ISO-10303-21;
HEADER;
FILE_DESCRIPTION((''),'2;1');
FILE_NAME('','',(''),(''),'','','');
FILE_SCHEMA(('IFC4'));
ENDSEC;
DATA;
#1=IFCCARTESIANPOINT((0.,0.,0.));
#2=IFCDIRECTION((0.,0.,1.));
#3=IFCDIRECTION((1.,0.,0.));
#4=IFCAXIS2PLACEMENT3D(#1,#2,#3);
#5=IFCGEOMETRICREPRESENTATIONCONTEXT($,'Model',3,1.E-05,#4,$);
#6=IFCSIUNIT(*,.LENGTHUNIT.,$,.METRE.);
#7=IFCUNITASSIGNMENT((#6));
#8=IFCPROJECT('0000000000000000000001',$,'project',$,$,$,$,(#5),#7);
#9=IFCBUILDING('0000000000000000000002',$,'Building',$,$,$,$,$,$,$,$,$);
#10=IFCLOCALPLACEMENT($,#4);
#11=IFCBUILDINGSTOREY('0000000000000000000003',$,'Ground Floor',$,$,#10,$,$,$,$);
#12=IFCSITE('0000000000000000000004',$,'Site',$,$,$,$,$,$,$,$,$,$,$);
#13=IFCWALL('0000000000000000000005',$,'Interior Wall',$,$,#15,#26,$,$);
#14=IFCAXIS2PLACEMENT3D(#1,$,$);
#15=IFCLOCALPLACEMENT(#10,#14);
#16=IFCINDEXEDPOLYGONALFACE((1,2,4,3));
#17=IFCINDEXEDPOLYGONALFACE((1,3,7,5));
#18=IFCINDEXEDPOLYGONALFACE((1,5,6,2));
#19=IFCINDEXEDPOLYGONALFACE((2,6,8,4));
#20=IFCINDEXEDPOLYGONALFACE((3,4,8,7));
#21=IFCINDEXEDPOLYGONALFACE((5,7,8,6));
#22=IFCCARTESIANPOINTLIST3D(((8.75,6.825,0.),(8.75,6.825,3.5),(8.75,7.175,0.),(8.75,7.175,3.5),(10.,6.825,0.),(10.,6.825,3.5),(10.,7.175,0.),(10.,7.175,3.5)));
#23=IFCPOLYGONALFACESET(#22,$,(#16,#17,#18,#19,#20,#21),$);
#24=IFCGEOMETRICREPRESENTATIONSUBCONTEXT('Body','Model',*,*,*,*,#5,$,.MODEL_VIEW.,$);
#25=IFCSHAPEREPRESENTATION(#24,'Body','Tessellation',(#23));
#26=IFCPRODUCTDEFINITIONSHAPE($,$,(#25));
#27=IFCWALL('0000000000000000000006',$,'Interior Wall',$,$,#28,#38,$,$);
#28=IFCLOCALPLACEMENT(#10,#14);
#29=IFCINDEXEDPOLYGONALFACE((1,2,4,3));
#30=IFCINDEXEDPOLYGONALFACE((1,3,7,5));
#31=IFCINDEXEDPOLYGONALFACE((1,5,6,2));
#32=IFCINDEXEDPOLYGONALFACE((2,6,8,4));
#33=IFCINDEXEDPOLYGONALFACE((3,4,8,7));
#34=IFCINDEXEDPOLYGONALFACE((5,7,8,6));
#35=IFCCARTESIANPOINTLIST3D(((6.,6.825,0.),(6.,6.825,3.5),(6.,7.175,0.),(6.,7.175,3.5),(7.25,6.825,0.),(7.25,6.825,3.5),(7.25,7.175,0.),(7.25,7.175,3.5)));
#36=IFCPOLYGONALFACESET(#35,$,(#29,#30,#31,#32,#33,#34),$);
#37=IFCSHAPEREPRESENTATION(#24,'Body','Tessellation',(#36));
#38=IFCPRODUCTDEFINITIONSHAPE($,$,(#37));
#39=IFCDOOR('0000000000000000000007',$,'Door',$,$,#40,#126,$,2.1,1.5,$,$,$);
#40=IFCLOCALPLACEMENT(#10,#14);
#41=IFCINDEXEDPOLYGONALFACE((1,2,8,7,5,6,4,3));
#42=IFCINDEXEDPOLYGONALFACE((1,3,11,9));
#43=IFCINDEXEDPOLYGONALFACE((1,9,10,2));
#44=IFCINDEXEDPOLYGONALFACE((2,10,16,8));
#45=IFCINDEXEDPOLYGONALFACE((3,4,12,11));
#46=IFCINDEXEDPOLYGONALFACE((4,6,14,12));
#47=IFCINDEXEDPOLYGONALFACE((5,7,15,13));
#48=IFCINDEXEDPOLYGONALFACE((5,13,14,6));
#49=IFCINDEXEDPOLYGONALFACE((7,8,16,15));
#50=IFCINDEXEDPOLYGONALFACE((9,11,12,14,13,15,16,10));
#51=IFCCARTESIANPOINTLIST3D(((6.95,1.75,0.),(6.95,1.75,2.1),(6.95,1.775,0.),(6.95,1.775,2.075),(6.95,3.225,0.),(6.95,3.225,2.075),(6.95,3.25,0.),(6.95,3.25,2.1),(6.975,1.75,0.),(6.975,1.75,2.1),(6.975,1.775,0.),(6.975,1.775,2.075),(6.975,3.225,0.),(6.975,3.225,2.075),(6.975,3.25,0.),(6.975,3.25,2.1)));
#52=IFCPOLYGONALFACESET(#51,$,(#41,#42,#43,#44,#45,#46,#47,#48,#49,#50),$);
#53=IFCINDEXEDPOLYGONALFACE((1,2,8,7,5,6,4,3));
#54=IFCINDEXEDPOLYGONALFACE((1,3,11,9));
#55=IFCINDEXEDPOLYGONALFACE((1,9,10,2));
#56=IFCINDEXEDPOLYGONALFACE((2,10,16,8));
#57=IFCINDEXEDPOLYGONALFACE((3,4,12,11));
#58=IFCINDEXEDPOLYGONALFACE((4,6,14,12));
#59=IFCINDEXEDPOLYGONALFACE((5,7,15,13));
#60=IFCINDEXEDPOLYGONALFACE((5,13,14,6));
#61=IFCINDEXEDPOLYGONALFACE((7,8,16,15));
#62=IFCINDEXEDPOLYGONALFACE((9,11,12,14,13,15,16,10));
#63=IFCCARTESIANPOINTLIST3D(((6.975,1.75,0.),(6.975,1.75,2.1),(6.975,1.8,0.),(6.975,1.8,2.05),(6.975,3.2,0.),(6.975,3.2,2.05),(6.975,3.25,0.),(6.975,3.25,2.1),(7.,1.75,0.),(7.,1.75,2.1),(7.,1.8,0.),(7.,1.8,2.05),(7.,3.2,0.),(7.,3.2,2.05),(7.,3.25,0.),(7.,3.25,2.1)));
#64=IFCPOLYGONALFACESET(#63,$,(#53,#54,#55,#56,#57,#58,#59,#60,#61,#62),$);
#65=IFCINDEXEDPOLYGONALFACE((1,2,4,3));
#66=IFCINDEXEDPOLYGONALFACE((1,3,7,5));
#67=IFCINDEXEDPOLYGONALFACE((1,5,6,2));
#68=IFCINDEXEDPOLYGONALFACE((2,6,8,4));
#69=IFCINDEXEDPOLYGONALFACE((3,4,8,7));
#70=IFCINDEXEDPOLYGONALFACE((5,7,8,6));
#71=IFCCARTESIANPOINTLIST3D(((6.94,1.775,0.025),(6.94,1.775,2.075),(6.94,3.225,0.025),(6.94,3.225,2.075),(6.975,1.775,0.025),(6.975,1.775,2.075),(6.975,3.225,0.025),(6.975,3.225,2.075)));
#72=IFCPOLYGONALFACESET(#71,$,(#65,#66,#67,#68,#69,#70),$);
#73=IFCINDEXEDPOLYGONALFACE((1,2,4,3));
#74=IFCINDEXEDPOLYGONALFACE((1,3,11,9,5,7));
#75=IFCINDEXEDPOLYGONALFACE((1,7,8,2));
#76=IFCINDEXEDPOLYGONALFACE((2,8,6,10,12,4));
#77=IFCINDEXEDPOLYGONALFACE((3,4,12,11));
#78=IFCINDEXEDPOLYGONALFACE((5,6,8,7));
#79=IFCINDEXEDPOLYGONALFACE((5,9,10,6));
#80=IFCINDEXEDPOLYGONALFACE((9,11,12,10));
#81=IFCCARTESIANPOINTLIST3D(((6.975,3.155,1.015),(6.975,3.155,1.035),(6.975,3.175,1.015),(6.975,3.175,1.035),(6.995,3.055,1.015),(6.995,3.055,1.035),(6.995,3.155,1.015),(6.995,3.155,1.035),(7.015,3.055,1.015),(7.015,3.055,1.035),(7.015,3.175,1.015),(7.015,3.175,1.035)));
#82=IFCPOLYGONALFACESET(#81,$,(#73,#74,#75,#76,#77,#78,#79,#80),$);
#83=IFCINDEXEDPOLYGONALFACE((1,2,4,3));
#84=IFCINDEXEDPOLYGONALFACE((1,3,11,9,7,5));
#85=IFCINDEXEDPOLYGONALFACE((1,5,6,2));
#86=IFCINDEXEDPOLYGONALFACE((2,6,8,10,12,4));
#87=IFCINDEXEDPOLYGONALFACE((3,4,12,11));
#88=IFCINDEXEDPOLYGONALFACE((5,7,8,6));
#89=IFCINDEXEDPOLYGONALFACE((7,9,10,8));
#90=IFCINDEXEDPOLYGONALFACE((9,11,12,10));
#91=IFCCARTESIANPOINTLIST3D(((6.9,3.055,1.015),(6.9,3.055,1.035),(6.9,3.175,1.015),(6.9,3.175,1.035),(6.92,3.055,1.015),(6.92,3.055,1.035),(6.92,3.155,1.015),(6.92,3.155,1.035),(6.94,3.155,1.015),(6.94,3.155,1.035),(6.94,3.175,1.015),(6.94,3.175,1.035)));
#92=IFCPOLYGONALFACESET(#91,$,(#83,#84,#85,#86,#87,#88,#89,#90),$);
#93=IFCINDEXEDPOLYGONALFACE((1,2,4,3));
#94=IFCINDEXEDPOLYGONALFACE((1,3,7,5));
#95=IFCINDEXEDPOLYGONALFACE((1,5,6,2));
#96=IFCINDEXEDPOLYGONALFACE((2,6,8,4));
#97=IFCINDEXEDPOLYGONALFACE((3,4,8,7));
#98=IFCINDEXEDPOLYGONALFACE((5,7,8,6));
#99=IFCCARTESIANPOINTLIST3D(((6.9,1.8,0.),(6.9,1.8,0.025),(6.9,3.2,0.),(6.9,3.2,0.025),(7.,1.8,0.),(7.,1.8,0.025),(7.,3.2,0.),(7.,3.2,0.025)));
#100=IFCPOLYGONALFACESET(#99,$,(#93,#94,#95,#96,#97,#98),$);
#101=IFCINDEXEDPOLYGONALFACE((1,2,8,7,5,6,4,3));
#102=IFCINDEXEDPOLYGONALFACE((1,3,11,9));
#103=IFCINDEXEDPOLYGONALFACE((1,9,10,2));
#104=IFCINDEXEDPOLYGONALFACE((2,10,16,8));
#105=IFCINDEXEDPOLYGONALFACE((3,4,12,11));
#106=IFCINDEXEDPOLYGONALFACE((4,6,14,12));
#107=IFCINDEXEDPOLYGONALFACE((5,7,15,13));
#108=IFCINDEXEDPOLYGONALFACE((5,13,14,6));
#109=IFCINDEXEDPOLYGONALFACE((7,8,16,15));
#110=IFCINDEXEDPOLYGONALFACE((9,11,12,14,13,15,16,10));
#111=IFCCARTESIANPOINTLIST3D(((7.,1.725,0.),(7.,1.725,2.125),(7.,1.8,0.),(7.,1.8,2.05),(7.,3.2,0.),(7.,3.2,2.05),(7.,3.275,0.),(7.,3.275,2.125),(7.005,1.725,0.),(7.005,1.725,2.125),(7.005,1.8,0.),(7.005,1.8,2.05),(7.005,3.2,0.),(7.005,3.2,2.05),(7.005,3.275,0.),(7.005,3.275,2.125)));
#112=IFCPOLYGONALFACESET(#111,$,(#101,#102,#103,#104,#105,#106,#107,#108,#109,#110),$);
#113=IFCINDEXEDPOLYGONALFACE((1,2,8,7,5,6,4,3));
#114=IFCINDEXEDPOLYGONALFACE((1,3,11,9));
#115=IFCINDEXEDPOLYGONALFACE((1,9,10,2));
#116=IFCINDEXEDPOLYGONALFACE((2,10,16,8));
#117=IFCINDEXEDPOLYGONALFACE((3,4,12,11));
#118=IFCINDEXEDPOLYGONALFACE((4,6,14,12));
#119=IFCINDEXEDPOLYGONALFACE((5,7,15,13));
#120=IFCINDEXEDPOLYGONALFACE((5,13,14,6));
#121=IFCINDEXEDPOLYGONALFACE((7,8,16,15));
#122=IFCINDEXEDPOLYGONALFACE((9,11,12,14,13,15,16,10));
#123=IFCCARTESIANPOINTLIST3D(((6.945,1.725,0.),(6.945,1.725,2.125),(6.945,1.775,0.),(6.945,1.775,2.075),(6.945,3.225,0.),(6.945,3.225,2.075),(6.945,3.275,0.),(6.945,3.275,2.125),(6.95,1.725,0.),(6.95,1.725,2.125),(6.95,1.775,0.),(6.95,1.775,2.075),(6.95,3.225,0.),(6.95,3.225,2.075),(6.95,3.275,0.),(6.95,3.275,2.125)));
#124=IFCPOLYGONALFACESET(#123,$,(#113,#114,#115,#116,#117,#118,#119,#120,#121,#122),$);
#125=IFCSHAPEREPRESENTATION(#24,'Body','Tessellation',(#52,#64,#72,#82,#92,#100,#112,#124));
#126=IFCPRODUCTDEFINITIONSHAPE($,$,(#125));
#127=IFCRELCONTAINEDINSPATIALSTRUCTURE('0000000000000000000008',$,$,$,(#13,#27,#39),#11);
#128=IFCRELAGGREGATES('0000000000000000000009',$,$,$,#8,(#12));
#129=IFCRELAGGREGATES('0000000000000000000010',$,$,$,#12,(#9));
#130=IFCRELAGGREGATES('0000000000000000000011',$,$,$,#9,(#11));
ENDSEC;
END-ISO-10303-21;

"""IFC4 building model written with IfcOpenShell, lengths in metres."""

from ifc_helpers import new_model, si_unit, frame, origin_with_axes, place, context, subcontext, project, spatial, line, indexed_curve, outline, extrude, element, save


model = new_model("IFC4")

# Units and contexts
model_context = context("Model", 3, precision=1e-05, world=origin_with_axes())
body_context = subcontext(model_context, "Body", "Model", "MODEL_VIEW")
ifc_project = project(units=[si_unit("LENGTHUNIT", "METRE")], contexts=[model_context])

# Site, building, storey
site = spatial("IfcSite", under=ifc_project, Name="Site")
building = spatial("IfcBuilding", under=site, Name="Building")
storey_placement = place(None, origin_with_axes())
storey = spatial("IfcBuildingStorey", under=building, at=storey_placement, Name="Ground Floor")

# Walls
for number, where, z_axis, x_axis, name in (
    (1, (10.0, 7.0, 0.0), (0.0, 0.0, 1.0), (-1.0, 0.0, 0.0), "Interior Wall"),
    (2, (7.25, 7.0, 0.0), (0.0, 0.0, 1.0), (-1.0, 0.0, 0.0), "Interior Wall"),
):
    element("IfcWall", number, at=place(storey_placement, frame(where, z_axis=z_axis, x_axis=x_axis)), inside=storey, Name=name, context=body_context, shape_type="SweptSolid", body=[
        extrude(outline(indexed_curve([(0.0, 0.0), (0.0, 0.35), (1.25, 0.35), (1.25, 0.0), (0.0, 0.0)], self_intersect=False)), frame((0.0, -0.175, 0.0), z_axis=(0.0, 0.0, 1.0), x_axis=(1.0, 0.0, 0.0)), (0.0, 0.0, 1.0), 3.5),
    ])

# Door
door_1_placement = place(storey_placement, frame((7.0, 1.75, 0.0), z_axis=(0.0, 0.0, 1.0), x_axis=(0.0, 1.0, 0.0)))
element("IfcDoor", 3, at=door_1_placement, inside=storey, Name="Door", OverallHeight=2.1, OverallWidth=1.5, context=body_context, shape_type="SweptSolid", body=[
    extrude(outline(indexed_curve([(0.0, 0.0), (0.0, 2.1), (1.5, 2.1), (1.5, 0.0), (1.475, 0.0), (1.475, 2.075), (0.025, 2.075), (0.025, 0.0)], segments=[line(1, 2, 3, 4, 5, 6, 7, 8, 1)])), frame((0.0, 0.025, 0.0), z_axis=(0.0, -1.0, 0.0), x_axis=(1.0, 0.0, 0.0)), (0.0, 0.0, -1.0), 0.025),
    extrude(outline(indexed_curve([(0.0, 0.0), (0.0, 2.1), (1.5, 2.1), (1.5, 0.0), (1.45, 0.0), (1.45, 2.05), (0.05, 2.05), (0.05, 0.0)], segments=[line(1, 2, 3, 4, 5, 6, 7, 8, 1)])), frame((0.0, 0.0, 0.0), z_axis=(0.0, -1.0, 0.0), x_axis=(1.0, 0.0, 0.0)), (0.0, 0.0, -1.0), 0.025),
    extrude(outline(indexed_curve([(0.0, 0.0), (1.45, 0.0), (1.45, 0.035), (0.0, 0.035)], segments=[line(1, 2, 3, 4, 1)])), frame((0.025, 0.025, 0.025), z_axis=(0.0, 0.0, 1.0), x_axis=(1.0, 0.0, 0.0)), (0.0, 0.0, 1.0), 2.05),
    extrude(outline(indexed_curve([(0.0, 0.0), (0.0, -0.04), (-0.12, -0.04), (-0.12, -0.02), (-0.02, -0.02), (-0.02, 0.0)], segments=[line(1, 2, 3, 4, 5, 6, 1)])), frame((1.425, 0.025, 1.015), z_axis=(0.0, 0.0, 1.0), x_axis=(1.0, 0.0, 0.0)), (0.0, 0.0, 1.0), 0.02),
    extrude(outline(indexed_curve([(0.0, 0.0), (0.0, 0.04), (-0.12, 0.04), (-0.12, 0.02), (-0.02, 0.02), (-0.02, 0.0)], segments=[line(1, 2, 3, 4, 5, 6, 1)])), frame((1.425, 0.06, 1.015), z_axis=(0.0, 0.0, 1.0), x_axis=(1.0, 0.0, 0.0)), (0.0, 0.0, 1.0), 0.02),
    extrude(outline(indexed_curve([(0.0, 0.0), (1.4, 0.0), (1.4, 0.1), (0.0, 0.1)], segments=[line(1, 2, 3, 4, 1)])), frame((0.05, 0.0, 0.0), z_axis=(0.0, 0.0, 1.0), x_axis=(1.0, 0.0, 0.0)), (0.0, 0.0, 1.0), 0.025),
    extrude(outline(indexed_curve([(0.0, 0.0), (0.0, 2.125), (1.55, 2.125), (1.55, 0.0), (1.475, 0.0), (1.475, 2.05), (0.075, 2.05), (0.075, 0.0)], segments=[line(1, 2, 3, 4, 5, 6, 7, 8, 1)])), frame((-0.025, -0.005, 0.0), z_axis=(0.0, -1.0, 0.0), x_axis=(1.0, 0.0, 0.0)), (0.0, 0.0, -1.0), 0.005),
    extrude(outline(indexed_curve([(0.0, 0.0), (0.0, 2.125), (1.55, 2.125), (1.55, 0.0), (1.5, 0.0), (1.5, 2.075), (0.05, 2.075), (0.05, 0.0)], segments=[line(1, 2, 3, 4, 5, 6, 7, 8, 1)])), frame((-0.025, 0.05, 0.0), z_axis=(0.0, -1.0, 0.0), x_axis=(1.0, 0.0, 0.0)), (0.0, 0.0, -1.0), 0.005),
])

save(model, "model.ifc")
